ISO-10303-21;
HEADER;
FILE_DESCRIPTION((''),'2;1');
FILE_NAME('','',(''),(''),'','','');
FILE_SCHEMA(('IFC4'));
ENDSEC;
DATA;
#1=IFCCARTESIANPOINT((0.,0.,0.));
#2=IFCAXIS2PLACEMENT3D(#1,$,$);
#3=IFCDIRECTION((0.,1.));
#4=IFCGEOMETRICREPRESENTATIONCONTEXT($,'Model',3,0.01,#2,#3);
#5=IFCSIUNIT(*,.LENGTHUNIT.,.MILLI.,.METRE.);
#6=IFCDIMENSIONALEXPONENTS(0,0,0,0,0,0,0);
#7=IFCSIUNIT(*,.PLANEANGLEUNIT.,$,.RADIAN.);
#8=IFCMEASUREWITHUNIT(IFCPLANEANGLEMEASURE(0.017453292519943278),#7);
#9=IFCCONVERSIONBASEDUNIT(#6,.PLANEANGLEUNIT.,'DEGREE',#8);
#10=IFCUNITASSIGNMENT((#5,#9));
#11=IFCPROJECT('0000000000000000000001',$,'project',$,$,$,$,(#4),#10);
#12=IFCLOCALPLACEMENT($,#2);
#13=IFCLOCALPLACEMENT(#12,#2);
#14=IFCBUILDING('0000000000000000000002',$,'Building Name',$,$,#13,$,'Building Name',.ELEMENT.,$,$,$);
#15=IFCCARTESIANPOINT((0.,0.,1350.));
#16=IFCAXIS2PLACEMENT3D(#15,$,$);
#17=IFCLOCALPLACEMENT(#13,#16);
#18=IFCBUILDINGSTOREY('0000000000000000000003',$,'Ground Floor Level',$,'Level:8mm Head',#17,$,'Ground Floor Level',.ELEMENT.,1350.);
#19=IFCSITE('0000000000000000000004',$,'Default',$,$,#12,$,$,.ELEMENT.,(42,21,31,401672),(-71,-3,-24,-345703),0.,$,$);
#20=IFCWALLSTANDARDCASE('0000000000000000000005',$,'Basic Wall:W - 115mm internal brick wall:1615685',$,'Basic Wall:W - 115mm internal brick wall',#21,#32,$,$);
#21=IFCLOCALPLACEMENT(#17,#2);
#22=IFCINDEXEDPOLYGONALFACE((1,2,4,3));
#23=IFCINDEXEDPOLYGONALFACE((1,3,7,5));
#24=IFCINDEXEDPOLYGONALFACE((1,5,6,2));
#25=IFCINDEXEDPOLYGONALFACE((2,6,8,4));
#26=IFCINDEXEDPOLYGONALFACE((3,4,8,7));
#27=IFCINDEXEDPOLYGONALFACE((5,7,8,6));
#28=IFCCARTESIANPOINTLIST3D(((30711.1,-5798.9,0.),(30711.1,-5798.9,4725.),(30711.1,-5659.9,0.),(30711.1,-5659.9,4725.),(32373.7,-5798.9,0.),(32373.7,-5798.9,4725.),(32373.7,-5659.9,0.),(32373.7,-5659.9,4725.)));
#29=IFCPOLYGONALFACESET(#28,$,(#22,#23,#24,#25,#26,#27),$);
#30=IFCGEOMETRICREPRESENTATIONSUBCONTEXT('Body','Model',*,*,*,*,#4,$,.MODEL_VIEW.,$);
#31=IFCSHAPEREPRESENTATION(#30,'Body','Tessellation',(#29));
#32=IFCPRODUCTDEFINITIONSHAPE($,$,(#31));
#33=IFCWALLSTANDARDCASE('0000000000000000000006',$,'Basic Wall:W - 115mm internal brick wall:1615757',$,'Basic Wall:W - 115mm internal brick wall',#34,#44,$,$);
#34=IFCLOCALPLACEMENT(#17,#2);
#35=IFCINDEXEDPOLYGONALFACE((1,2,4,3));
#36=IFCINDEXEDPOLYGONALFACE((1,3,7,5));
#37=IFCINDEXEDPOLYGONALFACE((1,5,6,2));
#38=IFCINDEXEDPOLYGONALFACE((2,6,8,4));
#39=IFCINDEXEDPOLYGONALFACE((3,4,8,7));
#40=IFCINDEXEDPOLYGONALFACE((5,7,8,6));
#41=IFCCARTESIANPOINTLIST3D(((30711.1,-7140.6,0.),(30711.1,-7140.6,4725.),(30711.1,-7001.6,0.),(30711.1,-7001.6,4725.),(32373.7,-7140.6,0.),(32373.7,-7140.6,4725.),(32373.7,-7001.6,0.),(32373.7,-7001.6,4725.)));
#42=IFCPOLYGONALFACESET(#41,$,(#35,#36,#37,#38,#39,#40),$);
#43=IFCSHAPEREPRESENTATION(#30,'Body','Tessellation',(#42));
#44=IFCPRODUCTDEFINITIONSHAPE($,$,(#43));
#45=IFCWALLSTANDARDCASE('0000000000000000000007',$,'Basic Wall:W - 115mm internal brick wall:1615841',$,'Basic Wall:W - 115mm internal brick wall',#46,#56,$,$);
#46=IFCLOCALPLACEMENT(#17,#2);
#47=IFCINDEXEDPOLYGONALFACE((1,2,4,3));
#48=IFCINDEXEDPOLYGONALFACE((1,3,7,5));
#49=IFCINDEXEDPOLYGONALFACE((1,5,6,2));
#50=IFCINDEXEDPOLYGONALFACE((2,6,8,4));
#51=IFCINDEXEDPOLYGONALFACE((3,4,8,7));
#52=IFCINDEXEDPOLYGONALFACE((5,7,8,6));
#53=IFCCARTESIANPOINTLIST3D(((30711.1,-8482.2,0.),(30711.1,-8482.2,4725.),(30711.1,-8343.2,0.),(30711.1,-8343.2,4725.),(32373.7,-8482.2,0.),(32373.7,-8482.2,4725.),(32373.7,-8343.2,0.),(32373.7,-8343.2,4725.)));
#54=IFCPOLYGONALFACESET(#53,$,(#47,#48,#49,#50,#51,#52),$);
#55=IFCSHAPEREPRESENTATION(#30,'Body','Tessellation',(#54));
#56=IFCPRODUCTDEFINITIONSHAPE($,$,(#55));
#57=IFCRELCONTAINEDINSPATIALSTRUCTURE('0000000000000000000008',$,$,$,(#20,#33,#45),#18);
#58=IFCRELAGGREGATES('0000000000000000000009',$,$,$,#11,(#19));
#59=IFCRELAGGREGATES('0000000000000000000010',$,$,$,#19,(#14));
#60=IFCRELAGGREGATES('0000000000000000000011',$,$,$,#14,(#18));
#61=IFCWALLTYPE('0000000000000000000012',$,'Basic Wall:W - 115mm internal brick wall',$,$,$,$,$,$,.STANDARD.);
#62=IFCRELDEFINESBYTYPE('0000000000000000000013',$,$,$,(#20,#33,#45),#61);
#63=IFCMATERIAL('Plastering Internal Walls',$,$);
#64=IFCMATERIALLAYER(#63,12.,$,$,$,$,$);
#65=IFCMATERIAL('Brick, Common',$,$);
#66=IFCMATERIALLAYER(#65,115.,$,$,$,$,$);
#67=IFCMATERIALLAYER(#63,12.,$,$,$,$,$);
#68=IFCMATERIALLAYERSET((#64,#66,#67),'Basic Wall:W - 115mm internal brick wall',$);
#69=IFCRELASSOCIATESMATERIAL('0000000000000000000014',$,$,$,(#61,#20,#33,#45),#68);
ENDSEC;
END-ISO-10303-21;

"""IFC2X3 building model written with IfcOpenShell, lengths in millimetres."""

from ifc_helpers import new_model, entity, si_unit, converted_unit, direction, frame, frame_2d, origin, place, context, subcontext, project, spatial, rectangle, extrude, material, layer, layer_set, layer_usage, type_object, element, save


model = new_model("IFC2X3")

# Units and contexts
model_context = context("Model", 3, precision=0.01, world=origin(), true_north=direction((0.0, 1.0)))
body_context = subcontext(model_context, "Body", "Model", "MODEL_VIEW")
ifc_project = project(units=[si_unit("LENGTHUNIT", "METRE", prefix="MILLI"), converted_unit("PLANEANGLEUNIT", "DEGREE", entity("IfcPlaneAngleMeasure", 0.017453292519943278), si_unit("PLANEANGLEUNIT", "RADIAN"), dimensions=[0, 0, 0, 0, 0, 0, 0])], contexts=[model_context])

# Site, building, storey
site_placement = place(None, origin())
site = spatial("IfcSite", under=ifc_project, at=site_placement, Name="Default", CompositionType="ELEMENT", RefLatitude=(42, 21, 31, 401672), RefLongitude=(-71, -3, -24, -345703), RefElevation=0.0)
building_placement = place(site_placement, origin())
building = spatial("IfcBuilding", under=site, at=building_placement, Name="Building Name", LongName="Building Name", CompositionType="ELEMENT")
storey_placement = place(building_placement, frame((0.0, 0.0, 1350.0)))
storey = spatial("IfcBuildingStorey", under=building, at=storey_placement, Name="Ground Floor Level", ObjectType="Level:8mm Head", LongName="Ground Floor Level", CompositionType="ELEMENT", Elevation=1350.0)

# Walls
ifc_material_1 = material(Name="Brick, Common")
ifc_material_2 = material(Name="Plastering Internal Walls")
ifc_layer_1 = layer(ifc_material_2, 12.0)
ifc_layer_2 = layer(ifc_material_1, 115.0)
ifc_layer_3 = layer(ifc_material_2, 12.0)
ifc_layer_set_1 = layer_set([ifc_layer_1, ifc_layer_2, ifc_layer_3], Name="Basic Wall:W - 115mm internal brick wall")
wall_type_1 = type_object("IfcWallType", Name="Basic Wall:W - 115mm internal brick wall", PredefinedType="STANDARD", material=ifc_layer_set_1)
ifc_layer_usage_1 = layer_usage(ifc_layer_set_1, "AXIS2", "NEGATIVE", 69.5)
wall_1_placement = place(storey_placement, frame((32373.7, -5729.4, 0.0), z_axis=(0.0, 0.0, 1.0), x_axis=(-1.0, 0.0, 0.0)))
element("IfcWallStandardCase", 1, at=wall_1_placement, inside=storey, type_object=wall_type_1, material=ifc_layer_usage_1, Name="Basic Wall:W - 115mm internal brick wall:1615685", ObjectType="Basic Wall:W - 115mm internal brick wall", context=body_context, shape_type="SweptSolid", body=[
    extrude(rectangle(XDim=1662.7, YDim=139.0, at=frame_2d((831.3, 0.0), x_axis=(-1.0, 0.0))), origin(), (0.0, 0.0, 1.0), 4725.0),
])
ifc_layer_usage_2 = layer_usage(ifc_layer_set_1, "AXIS2", "NEGATIVE", 69.5)
wall_2_placement = place(storey_placement, frame((32373.7, -7071.1, 0.0), z_axis=(0.0, 0.0, 1.0), x_axis=(-1.0, 0.0, 0.0)))
element("IfcWallStandardCase", 2, at=wall_2_placement, inside=storey, type_object=wall_type_1, material=ifc_layer_usage_2, Name="Basic Wall:W - 115mm internal brick wall:1615757", ObjectType="Basic Wall:W - 115mm internal brick wall", context=body_context, shape_type="SweptSolid", body=[
    extrude(rectangle(XDim=1662.7, YDim=139.0, at=frame_2d((831.3, 0.0), x_axis=(-1.0, 0.0))), origin(), (0.0, 0.0, 1.0), 4725.0),
])
ifc_layer_usage_3 = layer_usage(ifc_layer_set_1, "AXIS2", "NEGATIVE", 69.5)
wall_3_placement = place(storey_placement, frame((32373.7, -8412.7, 0.0), z_axis=(0.0, 0.0, 1.0), x_axis=(-1.0, 0.0, 0.0)))
element("IfcWallStandardCase", 3, at=wall_3_placement, inside=storey, type_object=wall_type_1, material=ifc_layer_usage_3, Name="Basic Wall:W - 115mm internal brick wall:1615841", ObjectType="Basic Wall:W - 115mm internal brick wall", context=body_context, shape_type="SweptSolid", body=[
    extrude(rectangle(XDim=1662.7, YDim=139.0, at=frame_2d((831.3, 0.0), x_axis=(-1.0, 0.0))), origin(), (0.0, 0.0, 1.0), 4725.0),
])

save(model, "model.ifc")
